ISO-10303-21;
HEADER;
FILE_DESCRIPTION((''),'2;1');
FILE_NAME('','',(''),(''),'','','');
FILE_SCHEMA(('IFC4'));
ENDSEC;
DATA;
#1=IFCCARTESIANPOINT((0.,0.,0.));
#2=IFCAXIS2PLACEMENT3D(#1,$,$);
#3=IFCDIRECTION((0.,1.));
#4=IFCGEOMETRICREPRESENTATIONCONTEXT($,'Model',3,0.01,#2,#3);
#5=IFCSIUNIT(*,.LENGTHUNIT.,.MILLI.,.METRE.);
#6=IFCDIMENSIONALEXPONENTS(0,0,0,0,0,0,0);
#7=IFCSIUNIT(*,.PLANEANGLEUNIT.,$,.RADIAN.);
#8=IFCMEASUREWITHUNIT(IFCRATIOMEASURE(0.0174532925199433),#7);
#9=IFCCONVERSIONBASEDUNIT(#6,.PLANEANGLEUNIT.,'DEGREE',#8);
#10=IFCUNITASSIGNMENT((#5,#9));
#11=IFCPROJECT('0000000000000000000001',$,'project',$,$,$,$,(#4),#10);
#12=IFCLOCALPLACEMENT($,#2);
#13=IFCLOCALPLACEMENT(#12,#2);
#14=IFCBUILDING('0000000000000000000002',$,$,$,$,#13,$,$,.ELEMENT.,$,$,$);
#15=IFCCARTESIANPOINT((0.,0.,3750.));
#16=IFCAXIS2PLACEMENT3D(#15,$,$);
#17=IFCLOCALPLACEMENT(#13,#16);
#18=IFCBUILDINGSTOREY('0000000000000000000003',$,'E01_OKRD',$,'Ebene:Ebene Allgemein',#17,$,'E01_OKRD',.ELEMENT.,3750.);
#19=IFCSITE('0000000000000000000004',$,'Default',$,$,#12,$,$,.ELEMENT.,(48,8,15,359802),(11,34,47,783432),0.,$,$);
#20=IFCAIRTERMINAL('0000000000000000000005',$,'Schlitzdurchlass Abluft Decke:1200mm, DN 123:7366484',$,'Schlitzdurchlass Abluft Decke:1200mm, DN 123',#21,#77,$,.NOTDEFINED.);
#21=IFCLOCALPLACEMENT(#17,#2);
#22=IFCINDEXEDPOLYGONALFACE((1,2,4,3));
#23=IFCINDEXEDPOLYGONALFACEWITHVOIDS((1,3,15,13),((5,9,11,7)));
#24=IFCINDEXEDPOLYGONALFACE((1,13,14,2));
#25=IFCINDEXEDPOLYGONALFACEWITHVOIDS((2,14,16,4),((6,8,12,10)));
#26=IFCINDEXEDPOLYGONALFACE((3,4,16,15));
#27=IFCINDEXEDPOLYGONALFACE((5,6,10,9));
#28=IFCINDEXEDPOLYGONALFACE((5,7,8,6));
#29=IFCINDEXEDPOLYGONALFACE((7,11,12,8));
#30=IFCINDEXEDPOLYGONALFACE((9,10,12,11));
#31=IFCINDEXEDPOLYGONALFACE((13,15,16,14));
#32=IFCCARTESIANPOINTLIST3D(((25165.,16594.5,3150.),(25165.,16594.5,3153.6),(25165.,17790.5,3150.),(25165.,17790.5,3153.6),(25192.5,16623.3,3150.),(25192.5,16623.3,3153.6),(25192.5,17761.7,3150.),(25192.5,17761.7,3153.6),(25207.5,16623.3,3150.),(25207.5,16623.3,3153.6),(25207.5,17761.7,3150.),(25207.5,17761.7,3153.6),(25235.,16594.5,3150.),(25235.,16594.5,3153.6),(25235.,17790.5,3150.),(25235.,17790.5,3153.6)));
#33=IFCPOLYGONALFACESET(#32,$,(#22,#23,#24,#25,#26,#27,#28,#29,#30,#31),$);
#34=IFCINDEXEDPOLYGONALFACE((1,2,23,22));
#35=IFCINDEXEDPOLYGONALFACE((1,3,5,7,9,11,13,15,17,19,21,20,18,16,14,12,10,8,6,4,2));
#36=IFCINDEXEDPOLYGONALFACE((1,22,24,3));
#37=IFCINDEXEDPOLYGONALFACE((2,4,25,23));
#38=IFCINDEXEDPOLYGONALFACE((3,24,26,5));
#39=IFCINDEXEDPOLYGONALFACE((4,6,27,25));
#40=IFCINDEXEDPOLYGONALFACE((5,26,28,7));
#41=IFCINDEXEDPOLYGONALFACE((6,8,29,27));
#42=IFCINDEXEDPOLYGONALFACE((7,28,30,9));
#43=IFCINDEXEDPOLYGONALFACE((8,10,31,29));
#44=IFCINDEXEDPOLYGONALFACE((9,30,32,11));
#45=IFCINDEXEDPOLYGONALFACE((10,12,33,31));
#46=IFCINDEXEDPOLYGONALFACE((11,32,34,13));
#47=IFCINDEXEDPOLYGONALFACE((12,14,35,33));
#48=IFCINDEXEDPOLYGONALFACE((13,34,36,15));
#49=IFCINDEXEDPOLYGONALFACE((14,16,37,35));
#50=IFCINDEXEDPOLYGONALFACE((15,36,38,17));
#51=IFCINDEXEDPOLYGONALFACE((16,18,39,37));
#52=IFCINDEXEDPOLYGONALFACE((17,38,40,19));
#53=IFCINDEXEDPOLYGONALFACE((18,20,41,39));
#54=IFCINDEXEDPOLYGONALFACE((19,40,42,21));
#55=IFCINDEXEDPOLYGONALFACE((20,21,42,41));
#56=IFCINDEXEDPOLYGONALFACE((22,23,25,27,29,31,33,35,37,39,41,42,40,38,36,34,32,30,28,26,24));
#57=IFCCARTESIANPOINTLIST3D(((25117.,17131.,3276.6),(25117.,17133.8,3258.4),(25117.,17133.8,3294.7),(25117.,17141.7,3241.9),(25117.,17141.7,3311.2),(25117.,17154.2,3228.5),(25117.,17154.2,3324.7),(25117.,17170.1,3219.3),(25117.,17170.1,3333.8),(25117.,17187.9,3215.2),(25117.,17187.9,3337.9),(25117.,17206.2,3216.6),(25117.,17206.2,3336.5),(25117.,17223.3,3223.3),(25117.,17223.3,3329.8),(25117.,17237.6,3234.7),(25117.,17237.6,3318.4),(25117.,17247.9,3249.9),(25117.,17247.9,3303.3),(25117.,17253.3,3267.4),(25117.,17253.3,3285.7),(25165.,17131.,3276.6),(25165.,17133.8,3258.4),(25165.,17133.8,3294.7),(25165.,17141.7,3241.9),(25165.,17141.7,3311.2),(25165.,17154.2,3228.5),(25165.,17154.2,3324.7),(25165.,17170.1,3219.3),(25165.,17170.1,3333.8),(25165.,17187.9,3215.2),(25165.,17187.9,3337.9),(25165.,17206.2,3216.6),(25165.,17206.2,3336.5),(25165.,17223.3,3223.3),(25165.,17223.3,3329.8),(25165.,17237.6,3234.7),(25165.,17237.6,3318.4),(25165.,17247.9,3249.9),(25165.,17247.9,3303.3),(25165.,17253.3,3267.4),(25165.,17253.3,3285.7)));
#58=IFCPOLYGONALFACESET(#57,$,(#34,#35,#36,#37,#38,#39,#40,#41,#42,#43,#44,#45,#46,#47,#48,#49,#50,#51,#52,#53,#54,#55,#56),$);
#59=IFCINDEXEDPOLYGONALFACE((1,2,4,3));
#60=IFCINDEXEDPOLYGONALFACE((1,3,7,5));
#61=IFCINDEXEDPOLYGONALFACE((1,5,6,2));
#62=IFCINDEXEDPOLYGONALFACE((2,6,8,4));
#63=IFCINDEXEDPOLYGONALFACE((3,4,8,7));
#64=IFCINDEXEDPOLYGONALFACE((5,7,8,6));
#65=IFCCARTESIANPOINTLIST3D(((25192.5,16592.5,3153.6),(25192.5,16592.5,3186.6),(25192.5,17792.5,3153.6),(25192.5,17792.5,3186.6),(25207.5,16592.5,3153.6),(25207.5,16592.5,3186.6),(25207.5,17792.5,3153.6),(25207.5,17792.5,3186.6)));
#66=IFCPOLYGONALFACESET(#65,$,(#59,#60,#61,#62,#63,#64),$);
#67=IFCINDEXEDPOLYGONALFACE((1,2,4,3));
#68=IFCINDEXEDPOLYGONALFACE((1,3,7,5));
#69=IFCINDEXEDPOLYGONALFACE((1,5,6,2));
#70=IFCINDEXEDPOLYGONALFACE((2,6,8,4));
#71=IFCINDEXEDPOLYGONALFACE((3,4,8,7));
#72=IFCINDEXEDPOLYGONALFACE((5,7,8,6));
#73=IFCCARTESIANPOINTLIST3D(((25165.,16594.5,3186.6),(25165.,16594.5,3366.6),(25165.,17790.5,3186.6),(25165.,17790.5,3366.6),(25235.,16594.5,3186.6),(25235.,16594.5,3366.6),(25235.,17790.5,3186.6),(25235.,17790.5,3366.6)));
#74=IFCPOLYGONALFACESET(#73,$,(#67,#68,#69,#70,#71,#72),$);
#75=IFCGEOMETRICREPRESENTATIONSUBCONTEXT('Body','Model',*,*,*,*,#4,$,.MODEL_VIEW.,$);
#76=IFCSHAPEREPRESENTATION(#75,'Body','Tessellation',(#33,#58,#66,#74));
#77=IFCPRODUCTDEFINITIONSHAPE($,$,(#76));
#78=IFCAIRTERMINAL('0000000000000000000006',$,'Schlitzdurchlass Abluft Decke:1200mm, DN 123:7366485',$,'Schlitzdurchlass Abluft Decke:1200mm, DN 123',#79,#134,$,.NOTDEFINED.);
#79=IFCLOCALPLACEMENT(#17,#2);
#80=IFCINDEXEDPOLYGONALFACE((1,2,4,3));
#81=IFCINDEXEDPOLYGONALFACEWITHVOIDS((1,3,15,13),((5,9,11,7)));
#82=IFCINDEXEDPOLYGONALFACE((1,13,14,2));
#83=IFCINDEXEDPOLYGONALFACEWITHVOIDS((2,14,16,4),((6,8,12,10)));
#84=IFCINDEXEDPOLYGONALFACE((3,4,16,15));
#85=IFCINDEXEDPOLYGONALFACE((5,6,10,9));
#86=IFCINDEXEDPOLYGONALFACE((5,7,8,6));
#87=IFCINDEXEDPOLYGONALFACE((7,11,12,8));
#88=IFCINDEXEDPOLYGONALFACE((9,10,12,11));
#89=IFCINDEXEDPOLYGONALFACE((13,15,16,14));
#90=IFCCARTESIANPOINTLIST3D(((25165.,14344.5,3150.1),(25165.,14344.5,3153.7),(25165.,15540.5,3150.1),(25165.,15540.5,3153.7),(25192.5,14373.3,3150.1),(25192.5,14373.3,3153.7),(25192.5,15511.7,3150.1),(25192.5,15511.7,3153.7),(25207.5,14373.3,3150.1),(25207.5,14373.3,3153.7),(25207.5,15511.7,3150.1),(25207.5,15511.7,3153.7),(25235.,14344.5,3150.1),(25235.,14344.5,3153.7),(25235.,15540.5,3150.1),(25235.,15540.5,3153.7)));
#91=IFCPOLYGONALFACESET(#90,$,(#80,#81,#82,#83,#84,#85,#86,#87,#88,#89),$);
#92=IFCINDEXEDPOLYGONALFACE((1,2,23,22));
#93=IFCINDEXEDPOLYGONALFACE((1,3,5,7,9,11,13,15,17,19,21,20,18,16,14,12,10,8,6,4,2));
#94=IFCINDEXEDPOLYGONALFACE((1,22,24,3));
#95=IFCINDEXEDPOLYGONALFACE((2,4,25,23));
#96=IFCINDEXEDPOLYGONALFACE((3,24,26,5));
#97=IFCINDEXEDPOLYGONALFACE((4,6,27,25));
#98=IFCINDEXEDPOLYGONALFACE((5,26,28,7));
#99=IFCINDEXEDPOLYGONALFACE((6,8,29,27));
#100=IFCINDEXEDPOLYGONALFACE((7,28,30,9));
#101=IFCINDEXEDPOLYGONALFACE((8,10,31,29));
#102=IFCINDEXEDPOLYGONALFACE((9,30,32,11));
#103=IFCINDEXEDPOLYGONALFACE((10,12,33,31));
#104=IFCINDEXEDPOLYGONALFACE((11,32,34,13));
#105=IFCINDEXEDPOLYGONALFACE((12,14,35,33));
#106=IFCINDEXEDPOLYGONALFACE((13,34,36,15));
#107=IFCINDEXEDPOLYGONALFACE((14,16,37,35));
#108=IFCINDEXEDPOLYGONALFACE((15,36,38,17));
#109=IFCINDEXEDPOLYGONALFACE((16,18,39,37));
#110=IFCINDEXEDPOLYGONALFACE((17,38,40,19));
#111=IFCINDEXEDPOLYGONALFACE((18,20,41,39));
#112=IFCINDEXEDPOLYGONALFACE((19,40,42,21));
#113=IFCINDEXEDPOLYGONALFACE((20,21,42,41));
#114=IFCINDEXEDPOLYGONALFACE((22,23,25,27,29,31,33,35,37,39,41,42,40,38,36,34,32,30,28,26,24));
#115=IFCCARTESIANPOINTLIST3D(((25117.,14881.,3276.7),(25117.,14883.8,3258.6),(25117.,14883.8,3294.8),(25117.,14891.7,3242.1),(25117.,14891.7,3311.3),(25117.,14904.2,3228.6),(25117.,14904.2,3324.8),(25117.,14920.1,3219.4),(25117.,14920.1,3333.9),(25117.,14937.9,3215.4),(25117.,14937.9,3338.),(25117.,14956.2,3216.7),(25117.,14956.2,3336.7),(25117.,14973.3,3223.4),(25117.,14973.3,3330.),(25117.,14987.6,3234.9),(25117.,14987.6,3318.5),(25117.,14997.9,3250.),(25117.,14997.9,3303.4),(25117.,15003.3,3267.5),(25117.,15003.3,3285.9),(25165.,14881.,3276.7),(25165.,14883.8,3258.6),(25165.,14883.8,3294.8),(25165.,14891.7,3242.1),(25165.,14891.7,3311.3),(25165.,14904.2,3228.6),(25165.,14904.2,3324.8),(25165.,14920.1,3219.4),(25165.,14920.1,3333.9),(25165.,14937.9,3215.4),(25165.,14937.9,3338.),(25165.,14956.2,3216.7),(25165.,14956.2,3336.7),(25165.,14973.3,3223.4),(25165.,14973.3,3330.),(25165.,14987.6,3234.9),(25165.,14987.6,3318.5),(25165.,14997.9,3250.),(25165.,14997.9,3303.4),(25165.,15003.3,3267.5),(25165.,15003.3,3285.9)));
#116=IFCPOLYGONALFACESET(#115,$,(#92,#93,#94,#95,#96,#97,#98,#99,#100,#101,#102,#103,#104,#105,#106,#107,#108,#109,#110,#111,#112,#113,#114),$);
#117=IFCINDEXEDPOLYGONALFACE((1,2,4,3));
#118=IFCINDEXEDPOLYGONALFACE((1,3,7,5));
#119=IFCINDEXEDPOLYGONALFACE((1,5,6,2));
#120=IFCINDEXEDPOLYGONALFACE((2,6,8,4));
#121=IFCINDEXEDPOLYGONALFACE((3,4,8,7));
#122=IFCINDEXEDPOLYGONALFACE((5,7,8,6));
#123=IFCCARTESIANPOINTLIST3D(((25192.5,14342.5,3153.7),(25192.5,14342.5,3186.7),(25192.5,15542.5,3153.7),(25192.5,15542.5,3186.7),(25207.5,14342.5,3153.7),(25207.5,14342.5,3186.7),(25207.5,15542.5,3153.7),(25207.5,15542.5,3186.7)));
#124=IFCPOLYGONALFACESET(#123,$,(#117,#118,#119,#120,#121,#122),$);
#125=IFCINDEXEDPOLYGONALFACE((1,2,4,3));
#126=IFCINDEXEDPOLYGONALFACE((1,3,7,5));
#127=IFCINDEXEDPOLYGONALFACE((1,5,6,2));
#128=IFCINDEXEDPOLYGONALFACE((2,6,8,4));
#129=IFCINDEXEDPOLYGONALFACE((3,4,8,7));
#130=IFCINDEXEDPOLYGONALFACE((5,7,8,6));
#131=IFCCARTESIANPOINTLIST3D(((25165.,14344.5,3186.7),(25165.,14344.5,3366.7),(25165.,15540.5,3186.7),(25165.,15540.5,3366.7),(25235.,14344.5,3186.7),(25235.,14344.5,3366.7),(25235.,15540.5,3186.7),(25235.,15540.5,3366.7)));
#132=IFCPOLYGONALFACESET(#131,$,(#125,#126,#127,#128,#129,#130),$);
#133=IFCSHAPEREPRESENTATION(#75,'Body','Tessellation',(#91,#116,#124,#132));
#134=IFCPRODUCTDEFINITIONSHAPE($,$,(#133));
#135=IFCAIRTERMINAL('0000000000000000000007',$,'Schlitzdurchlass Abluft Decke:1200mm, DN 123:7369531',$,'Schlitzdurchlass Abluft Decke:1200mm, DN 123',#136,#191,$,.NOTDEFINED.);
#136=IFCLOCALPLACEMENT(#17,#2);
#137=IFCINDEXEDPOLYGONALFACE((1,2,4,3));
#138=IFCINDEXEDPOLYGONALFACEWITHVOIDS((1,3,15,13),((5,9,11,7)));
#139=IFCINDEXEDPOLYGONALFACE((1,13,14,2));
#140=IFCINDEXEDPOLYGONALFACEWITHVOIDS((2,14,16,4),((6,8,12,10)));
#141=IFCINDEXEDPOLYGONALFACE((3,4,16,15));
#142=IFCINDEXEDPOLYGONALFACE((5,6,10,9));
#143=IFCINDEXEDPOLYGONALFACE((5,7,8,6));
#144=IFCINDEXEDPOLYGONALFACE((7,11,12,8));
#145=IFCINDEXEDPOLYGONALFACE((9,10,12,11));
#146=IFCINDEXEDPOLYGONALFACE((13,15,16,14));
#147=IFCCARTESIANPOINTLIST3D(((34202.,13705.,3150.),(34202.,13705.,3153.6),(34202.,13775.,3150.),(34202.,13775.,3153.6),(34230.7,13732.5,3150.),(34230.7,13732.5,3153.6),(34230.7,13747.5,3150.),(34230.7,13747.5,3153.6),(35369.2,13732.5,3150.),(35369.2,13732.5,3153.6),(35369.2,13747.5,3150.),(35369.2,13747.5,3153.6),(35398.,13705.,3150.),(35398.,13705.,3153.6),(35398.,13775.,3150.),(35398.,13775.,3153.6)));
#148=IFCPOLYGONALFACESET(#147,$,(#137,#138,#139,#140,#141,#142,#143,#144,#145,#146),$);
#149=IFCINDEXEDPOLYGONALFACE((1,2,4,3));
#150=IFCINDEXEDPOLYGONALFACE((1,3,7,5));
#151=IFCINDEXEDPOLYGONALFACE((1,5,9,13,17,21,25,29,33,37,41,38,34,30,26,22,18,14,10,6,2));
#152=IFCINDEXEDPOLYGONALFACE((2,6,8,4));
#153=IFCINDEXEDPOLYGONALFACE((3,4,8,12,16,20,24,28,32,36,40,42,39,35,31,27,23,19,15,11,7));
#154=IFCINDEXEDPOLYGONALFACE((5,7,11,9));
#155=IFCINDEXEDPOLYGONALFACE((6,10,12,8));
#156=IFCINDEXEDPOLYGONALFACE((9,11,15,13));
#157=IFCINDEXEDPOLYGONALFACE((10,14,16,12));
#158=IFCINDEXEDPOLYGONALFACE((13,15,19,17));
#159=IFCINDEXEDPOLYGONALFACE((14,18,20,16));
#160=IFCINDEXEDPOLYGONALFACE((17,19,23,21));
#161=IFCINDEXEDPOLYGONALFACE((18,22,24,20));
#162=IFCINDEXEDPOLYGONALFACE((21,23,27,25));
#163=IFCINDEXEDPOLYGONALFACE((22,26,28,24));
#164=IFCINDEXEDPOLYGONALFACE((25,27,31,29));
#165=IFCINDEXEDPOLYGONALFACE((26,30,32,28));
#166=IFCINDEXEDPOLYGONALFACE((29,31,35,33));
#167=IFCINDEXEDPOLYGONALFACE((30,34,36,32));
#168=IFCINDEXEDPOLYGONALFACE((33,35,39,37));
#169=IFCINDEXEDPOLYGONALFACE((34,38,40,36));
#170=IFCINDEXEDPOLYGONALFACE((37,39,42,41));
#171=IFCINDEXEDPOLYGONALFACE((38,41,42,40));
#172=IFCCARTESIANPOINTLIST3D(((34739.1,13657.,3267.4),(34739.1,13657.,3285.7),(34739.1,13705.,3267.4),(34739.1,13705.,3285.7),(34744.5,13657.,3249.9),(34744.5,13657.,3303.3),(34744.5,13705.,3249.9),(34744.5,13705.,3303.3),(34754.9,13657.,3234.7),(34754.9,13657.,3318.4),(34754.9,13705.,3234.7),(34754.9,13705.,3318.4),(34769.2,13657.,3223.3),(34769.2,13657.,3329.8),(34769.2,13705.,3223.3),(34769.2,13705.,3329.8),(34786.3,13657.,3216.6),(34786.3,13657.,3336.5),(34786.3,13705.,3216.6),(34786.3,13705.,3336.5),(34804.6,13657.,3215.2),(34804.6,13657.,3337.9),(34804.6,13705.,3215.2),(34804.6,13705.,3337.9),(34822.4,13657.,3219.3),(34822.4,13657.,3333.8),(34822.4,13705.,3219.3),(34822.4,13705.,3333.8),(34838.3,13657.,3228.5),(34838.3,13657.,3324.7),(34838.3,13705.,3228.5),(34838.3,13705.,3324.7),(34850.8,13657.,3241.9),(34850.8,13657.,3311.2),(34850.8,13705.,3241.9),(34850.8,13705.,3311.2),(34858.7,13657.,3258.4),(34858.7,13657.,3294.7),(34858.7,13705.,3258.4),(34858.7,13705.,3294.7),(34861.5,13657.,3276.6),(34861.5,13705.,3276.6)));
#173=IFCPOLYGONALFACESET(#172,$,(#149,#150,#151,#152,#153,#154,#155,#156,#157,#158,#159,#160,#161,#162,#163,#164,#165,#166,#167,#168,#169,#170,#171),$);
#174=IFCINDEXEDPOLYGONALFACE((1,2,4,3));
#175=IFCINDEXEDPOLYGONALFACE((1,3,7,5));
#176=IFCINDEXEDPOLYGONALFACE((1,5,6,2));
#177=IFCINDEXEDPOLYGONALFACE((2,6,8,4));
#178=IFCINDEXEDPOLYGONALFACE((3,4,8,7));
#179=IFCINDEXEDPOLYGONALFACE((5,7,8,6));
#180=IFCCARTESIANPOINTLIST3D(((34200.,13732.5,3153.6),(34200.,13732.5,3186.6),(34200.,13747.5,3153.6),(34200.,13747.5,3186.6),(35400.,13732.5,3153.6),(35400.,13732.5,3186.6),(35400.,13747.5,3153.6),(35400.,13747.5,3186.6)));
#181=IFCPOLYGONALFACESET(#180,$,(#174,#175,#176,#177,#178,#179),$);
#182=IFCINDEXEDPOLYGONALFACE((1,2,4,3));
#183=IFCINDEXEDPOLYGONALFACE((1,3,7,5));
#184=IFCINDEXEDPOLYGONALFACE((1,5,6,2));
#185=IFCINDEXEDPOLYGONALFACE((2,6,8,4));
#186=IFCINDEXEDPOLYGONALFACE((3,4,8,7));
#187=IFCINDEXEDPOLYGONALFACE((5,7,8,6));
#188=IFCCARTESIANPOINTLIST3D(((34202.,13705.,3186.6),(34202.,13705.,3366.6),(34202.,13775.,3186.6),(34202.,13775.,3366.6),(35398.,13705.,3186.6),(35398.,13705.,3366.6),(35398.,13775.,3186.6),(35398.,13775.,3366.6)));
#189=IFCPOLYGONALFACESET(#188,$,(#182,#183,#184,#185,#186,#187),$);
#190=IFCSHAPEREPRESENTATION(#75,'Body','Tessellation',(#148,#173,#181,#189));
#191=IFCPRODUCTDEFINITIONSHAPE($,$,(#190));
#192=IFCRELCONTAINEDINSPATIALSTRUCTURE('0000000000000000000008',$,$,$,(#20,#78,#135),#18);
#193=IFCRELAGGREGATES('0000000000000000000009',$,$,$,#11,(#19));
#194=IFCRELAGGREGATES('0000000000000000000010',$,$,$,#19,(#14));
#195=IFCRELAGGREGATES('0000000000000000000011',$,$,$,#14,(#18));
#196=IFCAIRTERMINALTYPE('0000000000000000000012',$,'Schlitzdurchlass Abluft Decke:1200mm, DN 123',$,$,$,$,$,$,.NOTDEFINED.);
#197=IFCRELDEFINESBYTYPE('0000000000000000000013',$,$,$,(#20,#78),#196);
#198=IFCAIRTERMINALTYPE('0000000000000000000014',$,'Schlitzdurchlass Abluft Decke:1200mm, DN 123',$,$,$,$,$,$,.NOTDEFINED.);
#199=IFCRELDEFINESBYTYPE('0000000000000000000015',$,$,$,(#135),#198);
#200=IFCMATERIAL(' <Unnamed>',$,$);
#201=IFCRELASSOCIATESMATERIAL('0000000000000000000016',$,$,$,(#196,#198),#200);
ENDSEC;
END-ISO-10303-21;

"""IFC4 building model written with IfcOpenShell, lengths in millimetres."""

from ifc_helpers import new_model, entity, si_unit, converted_unit, direction, frame, frame_2d, origin, origin_2d_with_axis, place, context, subcontext, project, spatial, polyline, rectangle, circle, outline, extrude, source, transform, mapped, material, type_object, type_shapes, element, save


model = new_model("IFC4")

# Units and contexts
model_context = context("Model", 3, precision=0.01, world=origin(), true_north=direction((0.0, 1.0)))
body_context = subcontext(model_context, "Body", "Model", "MODEL_VIEW")
ifc_project = project(units=[si_unit("LENGTHUNIT", "METRE", prefix="MILLI"), converted_unit("PLANEANGLEUNIT", "DEGREE", entity("IfcRatioMeasure", 0.0174532925199433), si_unit("PLANEANGLEUNIT", "RADIAN"), dimensions=[0, 0, 0, 0, 0, 0, 0])], contexts=[model_context])

# Site, building, storey
site_placement = place(None, origin())
site = spatial("IfcSite", under=ifc_project, at=site_placement, Name="Default", CompositionType="ELEMENT", RefLatitude=(48, 8, 15, 359802), RefLongitude=(11, 34, 47, 783432), RefElevation=0.0)
building_placement = place(site_placement, origin())
building = spatial("IfcBuilding", under=site, at=building_placement, CompositionType="ELEMENT")
storey_placement = place(building_placement, frame((0.0, 0.0, 3750.0)))
storey = spatial("IfcBuildingStorey", under=building, at=storey_placement, Name="E01_OKRD", ObjectType="Ebene:Ebene Allgemein", LongName="E01_OKRD", CompositionType="ELEMENT", Elevation=3750.0)

# Shared definitions
ifc_material_1 = material(Name=" <Unnamed>")

# Air terminals
air_terminal_type_1 = type_object("IfcAirTerminalType", Name="Schlitzdurchlass Abluft Decke:1200mm, DN 123", PredefinedType="NOTDEFINED", material=ifc_material_1)
shared_shape_1 = source(origin(), body_context, "Body", "SweptSolid", [
    extrude(outline(polyline([(-598.0, -35.0), (598.0, -35.0), (598.0, 35.0), (-598.0, 35.0), (-598.0, -35.0)]), holes=[polyline([(-569.2, -7.5), (-569.2, 7.5), (569.2, 7.5), (569.2, -7.5), (-569.2, -7.5)])]), frame((0.0, 0.0, 0.0), z_axis=(0.0, 0.0, 1.0), x_axis=(-1.0, 0.0, 0.0)), (0.0, 0.0, 1.0), 3.6),
    extrude(circle(Radius=61.5, at=frame_2d((0.0, 0.0), x_axis=(1.0, 0.0))), frame((0.0, 35.0, 126.6), z_axis=(0.0, 1.0, 0.0), x_axis=(-1.0, 0.0, 0.0)), (0.0, 0.0, 1.0), 48.0),
    extrude(rectangle(XDim=1200.0, YDim=15.0, at=origin_2d_with_axis()), frame((0.0, 0.0, 3.6), z_axis=(0.0, 0.0, 1.0), x_axis=(-1.0, 0.0, 0.0)), (0.0, 0.0, 1.0), 33.0),
    extrude(rectangle(XDim=1196.0, YDim=70.0, at=origin_2d_with_axis()), frame((0.0, 0.0, 36.6), z_axis=(0.0, 0.0, 1.0), x_axis=(-1.0, 0.0, 0.0)), (0.0, 0.0, 1.0), 180.0),
])
type_shapes(air_terminal_type_1, [shared_shape_1])
for number, where, z_axis, x_axis, name in (
    (1, (25200.0, 17192.5, 3150.0), (0.0, 0.0, 1.0), (0.0, 1.0, 0.0), "Schlitzdurchlass Abluft Decke:1200mm, DN 123:7366484"),
    (2, (25200.0, 14942.5, 3150.1), (0.0, 0.0, 1.0), (0.0, 1.0, 0.0), "Schlitzdurchlass Abluft Decke:1200mm, DN 123:7366485"),
):
    element("IfcAirTerminal", number, at=place(storey_placement, frame(where, z_axis=z_axis, x_axis=x_axis)), inside=storey, type_object=air_terminal_type_1, Name=name, ObjectType="Schlitzdurchlass Abluft Decke:1200mm, DN 123", PredefinedType="NOTDEFINED", context=body_context, shape_type="MappedRepresentation", body=[
        mapped(shared_shape_1, transform((0.0, 0.0, 0.0), scale=1.0)),
    ])
air_terminal_type_2 = type_object("IfcAirTerminalType", Name="Schlitzdurchlass Abluft Decke:1200mm, DN 123", PredefinedType="NOTDEFINED", material=ifc_material_1)
shared_shape_2 = source(origin(), body_context, "Body", "SweptSolid", [
    extrude(outline(polyline([(-598.0, -35.0), (598.0, -35.0), (598.0, 35.0), (-598.0, 35.0), (-598.0, -35.0)]), holes=[polyline([(-569.2, -7.5), (-569.2, 7.5), (569.2, 7.5), (569.2, -7.5), (-569.2, -7.5)])]), frame((0.0, 0.0, 0.0), z_axis=(0.0, 0.0, 1.0), x_axis=(-1.0, 0.0, 0.0)), (0.0, 0.0, 1.0), 3.6),
    extrude(circle(Radius=61.5, at=frame_2d((0.0, 0.0), x_axis=(1.0, 0.0))), frame((0.0, 35.0, 126.6), z_axis=(0.0, 1.0, 0.0), x_axis=(-1.0, 0.0, 0.0)), (0.0, 0.0, 1.0), 48.0),
    extrude(rectangle(XDim=1200.0, YDim=15.0, at=origin_2d_with_axis()), frame((0.0, 0.0, 3.6), z_axis=(0.0, 0.0, 1.0), x_axis=(-1.0, 0.0, 0.0)), (0.0, 0.0, 1.0), 33.0),
    extrude(rectangle(XDim=1196.0, YDim=70.0, at=origin_2d_with_axis()), frame((0.0, 0.0, 36.6), z_axis=(0.0, 0.0, 1.0), x_axis=(-1.0, 0.0, 0.0)), (0.0, 0.0, 1.0), 180.0),
])
type_shapes(air_terminal_type_2, [shared_shape_2])
for number, where, z_axis, x_axis, name in (
    (3, (34800.0, 13740.0, 3150.0), (0.0, 0.0, 1.0), (-1.0, 0.0, 0.0), "Schlitzdurchlass Abluft Decke:1200mm, DN 123:7369531"),
):
    element("IfcAirTerminal", number, at=place(storey_placement, frame(where, z_axis=z_axis, x_axis=x_axis)), inside=storey, type_object=air_terminal_type_2, Name=name, ObjectType="Schlitzdurchlass Abluft Decke:1200mm, DN 123", PredefinedType="NOTDEFINED", context=body_context, shape_type="MappedRepresentation", body=[
        mapped(shared_shape_2, transform((0.0, 0.0, 0.0), scale=1.0)),
    ])

save(model, "model.ifc")
